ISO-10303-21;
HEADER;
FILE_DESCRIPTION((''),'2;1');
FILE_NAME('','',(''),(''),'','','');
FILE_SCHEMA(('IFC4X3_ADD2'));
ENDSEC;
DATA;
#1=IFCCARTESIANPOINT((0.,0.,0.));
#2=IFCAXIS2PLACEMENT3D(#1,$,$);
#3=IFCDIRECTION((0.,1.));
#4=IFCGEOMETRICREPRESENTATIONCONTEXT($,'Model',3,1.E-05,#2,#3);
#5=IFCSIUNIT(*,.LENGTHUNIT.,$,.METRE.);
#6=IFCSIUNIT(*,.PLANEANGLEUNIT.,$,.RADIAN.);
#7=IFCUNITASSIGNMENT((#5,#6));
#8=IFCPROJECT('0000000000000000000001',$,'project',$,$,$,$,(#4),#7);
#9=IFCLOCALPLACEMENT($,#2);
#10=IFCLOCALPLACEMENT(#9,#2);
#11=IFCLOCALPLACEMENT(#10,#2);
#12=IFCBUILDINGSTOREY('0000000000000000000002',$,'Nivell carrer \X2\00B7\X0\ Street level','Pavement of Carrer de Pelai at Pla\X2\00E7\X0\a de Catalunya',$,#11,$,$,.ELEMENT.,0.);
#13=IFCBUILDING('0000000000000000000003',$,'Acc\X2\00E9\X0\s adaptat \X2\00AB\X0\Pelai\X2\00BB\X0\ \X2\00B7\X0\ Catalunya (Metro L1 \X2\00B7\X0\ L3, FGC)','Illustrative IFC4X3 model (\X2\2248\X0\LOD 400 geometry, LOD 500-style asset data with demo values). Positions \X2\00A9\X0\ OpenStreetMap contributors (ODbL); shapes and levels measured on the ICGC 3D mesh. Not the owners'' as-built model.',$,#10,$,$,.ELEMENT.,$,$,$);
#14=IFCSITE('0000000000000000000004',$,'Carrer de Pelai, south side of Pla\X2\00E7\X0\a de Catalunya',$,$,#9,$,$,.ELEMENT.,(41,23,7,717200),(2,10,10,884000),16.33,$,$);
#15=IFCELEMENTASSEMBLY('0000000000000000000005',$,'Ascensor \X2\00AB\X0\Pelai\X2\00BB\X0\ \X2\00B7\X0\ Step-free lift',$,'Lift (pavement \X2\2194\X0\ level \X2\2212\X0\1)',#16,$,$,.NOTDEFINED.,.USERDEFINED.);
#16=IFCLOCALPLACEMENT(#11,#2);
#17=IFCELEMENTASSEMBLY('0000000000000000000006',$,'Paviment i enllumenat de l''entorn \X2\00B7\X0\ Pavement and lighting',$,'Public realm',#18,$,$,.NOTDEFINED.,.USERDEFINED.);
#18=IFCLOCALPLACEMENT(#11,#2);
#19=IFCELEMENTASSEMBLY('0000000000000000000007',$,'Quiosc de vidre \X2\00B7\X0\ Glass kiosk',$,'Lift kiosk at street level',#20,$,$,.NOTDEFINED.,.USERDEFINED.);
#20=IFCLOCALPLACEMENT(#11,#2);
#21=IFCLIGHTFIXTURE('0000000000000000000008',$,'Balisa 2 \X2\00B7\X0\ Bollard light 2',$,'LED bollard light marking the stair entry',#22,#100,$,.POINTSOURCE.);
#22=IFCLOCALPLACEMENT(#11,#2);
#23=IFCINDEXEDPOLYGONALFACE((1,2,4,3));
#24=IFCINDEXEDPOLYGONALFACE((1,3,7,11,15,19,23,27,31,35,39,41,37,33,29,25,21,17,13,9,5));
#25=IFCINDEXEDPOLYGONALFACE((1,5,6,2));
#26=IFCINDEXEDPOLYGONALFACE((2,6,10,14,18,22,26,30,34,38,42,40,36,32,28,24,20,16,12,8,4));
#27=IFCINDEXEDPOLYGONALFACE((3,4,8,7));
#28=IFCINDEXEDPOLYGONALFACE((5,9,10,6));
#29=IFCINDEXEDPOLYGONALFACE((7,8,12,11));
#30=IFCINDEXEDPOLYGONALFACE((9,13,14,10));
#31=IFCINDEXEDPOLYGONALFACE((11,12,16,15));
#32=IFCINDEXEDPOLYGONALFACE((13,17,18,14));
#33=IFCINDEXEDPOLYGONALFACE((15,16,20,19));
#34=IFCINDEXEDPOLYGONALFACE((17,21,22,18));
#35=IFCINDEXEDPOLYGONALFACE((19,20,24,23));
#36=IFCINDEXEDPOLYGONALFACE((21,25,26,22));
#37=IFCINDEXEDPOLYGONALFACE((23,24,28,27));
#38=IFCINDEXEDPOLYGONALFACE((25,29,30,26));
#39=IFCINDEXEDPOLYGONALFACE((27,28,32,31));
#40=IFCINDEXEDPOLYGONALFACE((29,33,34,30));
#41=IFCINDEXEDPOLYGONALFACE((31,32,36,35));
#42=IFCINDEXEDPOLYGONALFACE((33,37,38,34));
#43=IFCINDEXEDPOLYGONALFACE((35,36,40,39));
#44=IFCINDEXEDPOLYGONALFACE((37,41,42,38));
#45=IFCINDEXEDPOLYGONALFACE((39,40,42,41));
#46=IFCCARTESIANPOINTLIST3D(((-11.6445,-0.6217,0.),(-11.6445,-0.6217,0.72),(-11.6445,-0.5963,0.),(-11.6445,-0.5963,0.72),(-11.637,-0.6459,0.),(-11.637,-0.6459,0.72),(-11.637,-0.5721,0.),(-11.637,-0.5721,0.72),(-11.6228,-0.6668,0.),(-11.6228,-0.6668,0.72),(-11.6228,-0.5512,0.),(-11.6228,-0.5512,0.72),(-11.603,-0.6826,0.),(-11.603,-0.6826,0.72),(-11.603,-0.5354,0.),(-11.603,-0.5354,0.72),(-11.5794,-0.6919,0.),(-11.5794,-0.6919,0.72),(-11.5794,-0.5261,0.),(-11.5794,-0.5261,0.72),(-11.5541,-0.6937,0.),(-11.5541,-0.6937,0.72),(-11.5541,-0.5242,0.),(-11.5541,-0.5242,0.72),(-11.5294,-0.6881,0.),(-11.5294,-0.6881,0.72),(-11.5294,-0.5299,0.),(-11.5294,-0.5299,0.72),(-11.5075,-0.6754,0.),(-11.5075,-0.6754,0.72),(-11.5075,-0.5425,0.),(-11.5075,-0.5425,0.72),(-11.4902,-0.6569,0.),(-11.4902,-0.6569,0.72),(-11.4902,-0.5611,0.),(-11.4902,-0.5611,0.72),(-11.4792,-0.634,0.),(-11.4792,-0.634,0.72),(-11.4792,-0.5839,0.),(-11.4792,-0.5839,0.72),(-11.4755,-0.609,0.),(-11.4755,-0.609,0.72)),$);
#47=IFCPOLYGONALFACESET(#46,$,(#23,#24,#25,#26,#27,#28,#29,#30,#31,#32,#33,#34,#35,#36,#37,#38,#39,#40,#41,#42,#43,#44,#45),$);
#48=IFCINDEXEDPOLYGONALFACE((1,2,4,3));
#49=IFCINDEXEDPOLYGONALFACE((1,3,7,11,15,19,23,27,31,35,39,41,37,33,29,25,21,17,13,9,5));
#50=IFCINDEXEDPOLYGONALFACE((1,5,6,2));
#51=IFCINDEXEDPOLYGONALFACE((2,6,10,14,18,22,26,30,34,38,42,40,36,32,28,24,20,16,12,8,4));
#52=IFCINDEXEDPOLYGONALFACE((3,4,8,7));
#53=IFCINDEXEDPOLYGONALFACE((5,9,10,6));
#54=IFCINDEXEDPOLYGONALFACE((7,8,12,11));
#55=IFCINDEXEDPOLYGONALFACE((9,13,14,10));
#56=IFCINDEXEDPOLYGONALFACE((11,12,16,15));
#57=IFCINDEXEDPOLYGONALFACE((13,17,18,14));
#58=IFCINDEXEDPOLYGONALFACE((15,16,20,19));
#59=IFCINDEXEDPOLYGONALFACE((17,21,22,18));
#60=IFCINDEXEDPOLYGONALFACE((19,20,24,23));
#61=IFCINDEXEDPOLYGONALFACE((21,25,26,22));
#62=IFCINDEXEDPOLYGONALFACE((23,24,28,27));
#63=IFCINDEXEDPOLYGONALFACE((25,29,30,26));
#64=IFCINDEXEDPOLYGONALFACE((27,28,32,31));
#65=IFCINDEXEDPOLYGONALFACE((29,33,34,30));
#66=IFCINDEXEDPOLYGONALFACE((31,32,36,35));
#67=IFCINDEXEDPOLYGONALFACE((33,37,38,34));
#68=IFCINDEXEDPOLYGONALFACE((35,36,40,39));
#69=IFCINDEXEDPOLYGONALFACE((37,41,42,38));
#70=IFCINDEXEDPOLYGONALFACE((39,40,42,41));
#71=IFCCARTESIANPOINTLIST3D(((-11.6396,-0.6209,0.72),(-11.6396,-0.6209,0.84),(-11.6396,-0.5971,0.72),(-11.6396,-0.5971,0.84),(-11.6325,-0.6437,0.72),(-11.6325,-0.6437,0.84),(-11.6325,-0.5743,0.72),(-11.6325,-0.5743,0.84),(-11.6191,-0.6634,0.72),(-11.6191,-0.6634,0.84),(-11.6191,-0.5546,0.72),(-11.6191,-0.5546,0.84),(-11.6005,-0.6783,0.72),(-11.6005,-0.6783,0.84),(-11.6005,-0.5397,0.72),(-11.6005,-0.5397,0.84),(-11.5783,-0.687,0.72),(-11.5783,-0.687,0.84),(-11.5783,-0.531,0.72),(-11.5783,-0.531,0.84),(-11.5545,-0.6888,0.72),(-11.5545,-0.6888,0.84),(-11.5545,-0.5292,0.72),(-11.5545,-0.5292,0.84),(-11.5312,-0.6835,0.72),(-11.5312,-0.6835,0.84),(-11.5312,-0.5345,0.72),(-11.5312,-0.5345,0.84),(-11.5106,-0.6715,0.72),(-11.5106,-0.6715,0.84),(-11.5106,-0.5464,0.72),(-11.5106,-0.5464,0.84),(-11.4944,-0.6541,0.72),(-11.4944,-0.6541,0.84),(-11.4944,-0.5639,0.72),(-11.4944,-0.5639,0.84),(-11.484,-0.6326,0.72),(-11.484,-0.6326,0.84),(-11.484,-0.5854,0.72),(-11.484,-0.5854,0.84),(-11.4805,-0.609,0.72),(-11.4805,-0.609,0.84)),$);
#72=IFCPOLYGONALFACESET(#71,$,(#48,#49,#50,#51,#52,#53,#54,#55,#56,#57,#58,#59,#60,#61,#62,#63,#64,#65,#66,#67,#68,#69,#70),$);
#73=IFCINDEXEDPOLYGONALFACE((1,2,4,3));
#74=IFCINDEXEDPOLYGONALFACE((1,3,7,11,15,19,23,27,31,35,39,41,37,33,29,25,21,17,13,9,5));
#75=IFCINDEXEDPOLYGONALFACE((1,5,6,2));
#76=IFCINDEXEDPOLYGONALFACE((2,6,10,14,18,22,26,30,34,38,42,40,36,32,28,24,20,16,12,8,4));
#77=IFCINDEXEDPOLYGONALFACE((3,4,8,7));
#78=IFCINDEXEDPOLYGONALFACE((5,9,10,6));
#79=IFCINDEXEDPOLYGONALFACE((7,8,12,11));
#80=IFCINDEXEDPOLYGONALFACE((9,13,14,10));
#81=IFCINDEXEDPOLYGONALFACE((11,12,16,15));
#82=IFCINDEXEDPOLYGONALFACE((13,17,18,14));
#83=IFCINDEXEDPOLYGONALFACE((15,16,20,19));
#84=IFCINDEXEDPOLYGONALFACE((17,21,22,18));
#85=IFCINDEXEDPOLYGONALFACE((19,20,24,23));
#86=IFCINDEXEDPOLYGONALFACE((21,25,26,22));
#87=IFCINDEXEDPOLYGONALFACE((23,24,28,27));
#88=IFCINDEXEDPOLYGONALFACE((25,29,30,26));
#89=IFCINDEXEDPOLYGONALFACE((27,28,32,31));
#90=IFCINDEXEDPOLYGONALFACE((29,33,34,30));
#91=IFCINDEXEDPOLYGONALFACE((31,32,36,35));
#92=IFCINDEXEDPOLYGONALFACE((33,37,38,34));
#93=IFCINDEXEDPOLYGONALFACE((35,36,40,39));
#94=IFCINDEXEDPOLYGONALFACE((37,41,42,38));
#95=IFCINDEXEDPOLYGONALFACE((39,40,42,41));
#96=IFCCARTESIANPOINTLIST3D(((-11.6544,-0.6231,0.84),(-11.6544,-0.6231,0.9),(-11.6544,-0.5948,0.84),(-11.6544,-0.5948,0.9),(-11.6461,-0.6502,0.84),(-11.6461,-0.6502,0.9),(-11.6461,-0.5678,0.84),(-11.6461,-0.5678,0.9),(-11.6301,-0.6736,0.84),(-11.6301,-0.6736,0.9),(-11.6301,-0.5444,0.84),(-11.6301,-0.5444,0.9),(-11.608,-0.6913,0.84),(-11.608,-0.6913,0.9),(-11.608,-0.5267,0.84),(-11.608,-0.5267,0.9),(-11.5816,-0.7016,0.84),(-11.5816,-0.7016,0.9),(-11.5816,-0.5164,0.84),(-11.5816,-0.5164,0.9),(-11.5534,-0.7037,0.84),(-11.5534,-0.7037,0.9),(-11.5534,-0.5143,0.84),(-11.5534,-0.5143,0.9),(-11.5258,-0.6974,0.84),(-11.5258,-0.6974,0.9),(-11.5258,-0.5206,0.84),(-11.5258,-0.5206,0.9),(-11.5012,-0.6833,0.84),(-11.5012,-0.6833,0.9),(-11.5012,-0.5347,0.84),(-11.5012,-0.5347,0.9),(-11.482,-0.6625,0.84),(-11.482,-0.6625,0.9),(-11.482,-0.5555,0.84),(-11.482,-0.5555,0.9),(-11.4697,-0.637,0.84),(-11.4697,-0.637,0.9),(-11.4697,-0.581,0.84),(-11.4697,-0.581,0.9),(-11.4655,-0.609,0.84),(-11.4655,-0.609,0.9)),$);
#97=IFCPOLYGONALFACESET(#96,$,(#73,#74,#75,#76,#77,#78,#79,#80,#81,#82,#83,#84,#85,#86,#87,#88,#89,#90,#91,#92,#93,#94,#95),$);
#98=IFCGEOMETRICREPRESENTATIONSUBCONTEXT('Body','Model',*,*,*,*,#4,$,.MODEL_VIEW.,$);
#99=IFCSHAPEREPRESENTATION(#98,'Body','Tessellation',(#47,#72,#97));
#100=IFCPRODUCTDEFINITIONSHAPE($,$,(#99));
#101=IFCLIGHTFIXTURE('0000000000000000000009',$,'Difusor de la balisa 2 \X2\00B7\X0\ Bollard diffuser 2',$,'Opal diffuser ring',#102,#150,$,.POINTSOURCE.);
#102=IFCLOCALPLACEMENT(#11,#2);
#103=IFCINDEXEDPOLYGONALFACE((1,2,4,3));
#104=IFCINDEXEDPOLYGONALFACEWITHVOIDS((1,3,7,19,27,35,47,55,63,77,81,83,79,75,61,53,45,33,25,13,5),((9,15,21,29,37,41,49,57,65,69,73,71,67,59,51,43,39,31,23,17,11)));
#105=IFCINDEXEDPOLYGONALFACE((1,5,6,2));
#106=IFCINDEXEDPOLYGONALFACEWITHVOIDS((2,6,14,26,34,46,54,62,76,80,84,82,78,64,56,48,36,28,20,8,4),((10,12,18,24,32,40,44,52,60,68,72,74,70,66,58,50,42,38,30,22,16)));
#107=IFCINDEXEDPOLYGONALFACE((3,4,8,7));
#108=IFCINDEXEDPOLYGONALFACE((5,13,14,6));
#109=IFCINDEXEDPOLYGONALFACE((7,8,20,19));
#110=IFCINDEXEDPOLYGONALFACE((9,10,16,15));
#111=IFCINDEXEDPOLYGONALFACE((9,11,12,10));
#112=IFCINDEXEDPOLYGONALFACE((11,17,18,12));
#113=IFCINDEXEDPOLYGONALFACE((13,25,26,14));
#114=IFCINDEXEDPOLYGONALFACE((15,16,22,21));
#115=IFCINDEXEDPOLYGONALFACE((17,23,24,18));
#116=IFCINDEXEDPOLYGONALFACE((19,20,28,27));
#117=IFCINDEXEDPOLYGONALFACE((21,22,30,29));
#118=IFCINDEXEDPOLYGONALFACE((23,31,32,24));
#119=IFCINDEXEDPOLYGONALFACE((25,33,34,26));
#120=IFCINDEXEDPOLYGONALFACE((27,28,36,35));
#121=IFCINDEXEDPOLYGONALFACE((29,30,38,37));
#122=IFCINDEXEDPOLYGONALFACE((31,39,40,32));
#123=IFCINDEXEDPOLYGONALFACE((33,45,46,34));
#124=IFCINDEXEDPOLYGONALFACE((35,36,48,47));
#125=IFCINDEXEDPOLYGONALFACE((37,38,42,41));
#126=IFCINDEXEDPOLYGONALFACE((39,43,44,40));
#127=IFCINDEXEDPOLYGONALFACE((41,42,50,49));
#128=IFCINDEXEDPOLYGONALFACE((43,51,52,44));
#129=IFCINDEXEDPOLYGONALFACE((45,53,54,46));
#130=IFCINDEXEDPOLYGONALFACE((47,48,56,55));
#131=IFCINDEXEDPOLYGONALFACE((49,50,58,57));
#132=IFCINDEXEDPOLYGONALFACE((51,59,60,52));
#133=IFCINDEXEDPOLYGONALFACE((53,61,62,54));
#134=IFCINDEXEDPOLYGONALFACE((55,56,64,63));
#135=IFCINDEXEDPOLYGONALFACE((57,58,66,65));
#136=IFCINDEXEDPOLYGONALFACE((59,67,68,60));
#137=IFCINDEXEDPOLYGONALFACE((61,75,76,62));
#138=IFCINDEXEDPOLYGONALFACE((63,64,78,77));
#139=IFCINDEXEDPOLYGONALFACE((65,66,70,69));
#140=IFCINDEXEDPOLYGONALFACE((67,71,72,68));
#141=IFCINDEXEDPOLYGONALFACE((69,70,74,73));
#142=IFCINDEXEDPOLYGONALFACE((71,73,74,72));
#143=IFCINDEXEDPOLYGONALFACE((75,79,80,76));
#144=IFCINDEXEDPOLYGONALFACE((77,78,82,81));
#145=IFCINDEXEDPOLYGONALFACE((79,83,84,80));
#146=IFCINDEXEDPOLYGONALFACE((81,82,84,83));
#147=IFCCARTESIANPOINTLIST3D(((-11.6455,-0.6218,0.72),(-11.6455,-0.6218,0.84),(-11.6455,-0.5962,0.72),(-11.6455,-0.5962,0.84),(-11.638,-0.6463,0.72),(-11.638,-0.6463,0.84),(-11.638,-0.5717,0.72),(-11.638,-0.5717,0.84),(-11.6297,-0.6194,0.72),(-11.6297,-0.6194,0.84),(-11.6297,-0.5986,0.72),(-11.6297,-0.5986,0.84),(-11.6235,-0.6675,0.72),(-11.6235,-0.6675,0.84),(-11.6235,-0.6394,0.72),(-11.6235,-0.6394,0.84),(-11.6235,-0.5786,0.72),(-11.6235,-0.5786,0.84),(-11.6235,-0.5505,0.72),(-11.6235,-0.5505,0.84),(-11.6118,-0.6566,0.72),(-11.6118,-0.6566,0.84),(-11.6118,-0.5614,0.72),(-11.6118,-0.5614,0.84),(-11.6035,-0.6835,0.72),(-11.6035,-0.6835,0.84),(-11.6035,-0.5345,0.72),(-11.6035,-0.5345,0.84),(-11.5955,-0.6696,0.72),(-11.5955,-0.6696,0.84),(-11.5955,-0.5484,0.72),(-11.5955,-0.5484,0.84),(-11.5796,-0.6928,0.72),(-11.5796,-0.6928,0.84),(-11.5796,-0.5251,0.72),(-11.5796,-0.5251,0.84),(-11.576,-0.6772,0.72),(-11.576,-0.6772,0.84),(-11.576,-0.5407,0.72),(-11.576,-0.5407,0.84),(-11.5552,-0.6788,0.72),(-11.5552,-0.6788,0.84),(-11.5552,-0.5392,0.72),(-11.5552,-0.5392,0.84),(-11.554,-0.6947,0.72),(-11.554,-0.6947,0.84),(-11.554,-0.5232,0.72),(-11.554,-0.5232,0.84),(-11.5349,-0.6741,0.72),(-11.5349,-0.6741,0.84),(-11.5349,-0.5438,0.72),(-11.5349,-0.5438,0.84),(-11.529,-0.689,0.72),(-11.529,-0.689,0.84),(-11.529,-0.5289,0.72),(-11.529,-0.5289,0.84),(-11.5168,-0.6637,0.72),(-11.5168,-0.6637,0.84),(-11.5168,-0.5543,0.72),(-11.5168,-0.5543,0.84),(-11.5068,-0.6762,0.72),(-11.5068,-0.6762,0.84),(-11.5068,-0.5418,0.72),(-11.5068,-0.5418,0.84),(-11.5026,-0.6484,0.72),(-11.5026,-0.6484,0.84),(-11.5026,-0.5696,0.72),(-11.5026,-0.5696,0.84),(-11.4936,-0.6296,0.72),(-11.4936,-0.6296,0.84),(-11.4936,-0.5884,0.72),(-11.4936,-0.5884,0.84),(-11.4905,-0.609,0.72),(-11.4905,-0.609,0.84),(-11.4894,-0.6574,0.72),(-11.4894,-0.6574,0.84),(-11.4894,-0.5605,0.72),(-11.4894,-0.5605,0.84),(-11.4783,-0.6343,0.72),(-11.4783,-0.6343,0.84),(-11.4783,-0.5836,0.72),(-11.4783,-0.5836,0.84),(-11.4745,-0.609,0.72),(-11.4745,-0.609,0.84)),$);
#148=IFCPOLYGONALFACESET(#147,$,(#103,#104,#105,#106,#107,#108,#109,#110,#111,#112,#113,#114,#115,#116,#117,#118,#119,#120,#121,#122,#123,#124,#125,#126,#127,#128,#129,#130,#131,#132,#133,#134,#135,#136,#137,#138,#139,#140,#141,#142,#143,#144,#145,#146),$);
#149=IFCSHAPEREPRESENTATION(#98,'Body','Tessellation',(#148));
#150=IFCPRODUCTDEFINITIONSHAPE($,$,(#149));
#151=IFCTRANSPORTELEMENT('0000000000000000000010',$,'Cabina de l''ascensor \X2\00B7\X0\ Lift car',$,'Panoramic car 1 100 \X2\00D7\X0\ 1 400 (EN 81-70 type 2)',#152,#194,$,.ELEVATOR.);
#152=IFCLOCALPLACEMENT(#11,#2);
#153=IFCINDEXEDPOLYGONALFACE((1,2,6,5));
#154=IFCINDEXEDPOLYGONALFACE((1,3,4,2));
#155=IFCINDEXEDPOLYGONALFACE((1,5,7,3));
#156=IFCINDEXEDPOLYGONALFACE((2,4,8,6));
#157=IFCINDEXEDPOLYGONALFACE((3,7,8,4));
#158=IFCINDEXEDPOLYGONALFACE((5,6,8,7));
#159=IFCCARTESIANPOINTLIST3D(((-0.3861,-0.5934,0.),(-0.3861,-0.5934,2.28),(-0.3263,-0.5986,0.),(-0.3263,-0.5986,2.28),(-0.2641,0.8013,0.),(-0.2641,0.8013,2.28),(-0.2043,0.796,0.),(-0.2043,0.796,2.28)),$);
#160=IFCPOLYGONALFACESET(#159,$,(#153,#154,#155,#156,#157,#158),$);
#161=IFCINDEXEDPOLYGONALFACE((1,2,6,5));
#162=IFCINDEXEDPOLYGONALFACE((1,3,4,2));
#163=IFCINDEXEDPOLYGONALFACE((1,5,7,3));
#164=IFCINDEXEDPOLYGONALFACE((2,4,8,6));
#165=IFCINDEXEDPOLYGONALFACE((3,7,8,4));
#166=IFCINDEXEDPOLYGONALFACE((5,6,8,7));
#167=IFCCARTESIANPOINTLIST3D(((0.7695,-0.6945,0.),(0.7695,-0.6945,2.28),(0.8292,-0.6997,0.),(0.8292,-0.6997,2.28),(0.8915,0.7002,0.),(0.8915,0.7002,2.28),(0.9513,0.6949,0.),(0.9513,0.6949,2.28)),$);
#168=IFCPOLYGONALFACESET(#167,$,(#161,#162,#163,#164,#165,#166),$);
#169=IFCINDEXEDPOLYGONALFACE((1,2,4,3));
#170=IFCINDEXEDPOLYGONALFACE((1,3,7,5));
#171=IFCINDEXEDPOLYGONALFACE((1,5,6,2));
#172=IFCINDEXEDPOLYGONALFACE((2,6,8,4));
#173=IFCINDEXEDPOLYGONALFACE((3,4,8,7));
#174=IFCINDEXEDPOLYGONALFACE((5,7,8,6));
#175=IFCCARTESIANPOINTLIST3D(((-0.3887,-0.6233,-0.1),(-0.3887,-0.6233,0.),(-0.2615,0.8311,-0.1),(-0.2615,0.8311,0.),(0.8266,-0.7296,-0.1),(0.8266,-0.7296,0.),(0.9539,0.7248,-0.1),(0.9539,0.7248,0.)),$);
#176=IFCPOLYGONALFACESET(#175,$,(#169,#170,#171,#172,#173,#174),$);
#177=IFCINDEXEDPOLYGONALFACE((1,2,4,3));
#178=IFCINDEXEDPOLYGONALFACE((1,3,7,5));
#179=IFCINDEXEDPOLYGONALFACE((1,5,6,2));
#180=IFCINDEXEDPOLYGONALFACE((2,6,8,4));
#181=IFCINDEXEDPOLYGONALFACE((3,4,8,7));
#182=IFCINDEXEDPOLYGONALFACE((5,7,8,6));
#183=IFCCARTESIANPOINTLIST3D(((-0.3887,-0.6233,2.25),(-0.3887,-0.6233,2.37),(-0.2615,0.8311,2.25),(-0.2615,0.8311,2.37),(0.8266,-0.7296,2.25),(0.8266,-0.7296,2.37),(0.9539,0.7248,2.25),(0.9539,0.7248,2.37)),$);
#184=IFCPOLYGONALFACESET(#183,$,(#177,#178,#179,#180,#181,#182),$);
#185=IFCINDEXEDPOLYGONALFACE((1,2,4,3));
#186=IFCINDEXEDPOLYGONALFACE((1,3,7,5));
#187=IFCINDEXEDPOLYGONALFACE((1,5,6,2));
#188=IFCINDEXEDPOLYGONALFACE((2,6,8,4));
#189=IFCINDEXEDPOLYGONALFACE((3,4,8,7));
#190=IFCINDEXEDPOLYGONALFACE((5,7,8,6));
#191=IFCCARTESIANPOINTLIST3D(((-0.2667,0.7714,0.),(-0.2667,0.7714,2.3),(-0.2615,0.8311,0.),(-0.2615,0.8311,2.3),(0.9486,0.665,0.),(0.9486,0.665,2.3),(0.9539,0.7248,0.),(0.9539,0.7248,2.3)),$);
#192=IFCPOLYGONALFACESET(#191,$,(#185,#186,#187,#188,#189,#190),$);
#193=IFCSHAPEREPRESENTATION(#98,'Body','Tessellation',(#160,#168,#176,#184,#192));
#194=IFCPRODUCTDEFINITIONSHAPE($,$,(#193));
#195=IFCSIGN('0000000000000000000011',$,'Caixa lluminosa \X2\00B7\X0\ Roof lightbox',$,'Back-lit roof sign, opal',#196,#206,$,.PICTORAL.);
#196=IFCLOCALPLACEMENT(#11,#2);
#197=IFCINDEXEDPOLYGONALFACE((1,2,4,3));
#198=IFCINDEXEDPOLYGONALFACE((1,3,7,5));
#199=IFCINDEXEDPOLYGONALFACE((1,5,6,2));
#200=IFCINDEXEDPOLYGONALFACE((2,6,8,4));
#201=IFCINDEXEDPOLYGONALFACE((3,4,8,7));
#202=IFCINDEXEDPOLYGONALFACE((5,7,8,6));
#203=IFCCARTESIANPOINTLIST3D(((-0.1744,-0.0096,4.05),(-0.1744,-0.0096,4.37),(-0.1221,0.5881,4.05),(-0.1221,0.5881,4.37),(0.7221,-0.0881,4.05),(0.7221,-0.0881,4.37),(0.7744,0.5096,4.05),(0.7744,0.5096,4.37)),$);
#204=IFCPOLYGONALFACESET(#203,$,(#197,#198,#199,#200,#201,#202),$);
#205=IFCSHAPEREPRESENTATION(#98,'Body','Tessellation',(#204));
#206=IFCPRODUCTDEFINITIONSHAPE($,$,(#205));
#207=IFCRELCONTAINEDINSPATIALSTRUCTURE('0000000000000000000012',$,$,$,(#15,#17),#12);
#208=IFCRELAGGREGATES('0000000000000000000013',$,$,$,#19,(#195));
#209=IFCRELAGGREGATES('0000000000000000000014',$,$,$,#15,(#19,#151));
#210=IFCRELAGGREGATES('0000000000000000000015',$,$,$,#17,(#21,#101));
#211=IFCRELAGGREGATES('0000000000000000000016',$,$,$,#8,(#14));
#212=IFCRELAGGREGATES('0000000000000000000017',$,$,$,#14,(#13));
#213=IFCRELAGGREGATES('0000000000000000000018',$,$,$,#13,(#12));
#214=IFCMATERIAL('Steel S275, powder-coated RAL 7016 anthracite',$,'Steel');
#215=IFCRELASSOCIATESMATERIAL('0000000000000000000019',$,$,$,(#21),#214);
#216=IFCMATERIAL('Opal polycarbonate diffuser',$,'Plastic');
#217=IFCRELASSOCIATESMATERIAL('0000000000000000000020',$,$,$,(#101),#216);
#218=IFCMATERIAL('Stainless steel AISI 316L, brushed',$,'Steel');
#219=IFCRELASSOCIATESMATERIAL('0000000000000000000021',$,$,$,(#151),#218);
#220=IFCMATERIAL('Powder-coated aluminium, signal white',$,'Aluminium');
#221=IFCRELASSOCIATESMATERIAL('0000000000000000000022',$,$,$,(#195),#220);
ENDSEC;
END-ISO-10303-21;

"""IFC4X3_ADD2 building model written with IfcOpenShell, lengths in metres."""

from ifc_helpers import new_model, si_unit, direction, frame, frame_2d, origin, origin_2d_with_axis, place, context, subcontext, project, spatial, rectangle, circle, hollow_circle, extrude, material, element, aggregate, save


model = new_model("IFC4X3_ADD2")

# Units and contexts
model_context = context("Model", 3, precision=1e-05, world=origin(), true_north=direction((0.0, 1.0)))
body_context = subcontext(model_context, "Body", "Model", "MODEL_VIEW")
ifc_project = project(units=[si_unit("LENGTHUNIT", "METRE"), si_unit("PLANEANGLEUNIT", "RADIAN")], contexts=[model_context])

# Site, building, storey
site_placement = place(None, origin())
site = spatial("IfcSite", under=ifc_project, at=site_placement, Name="Carrer de Pelai, south side of Plaça de Catalunya", CompositionType="ELEMENT", RefLatitude=(41, 23, 7, 717200), RefLongitude=(2, 10, 10, 884000), RefElevation=16.33)
building_placement = place(site_placement, origin())
building = spatial("IfcBuilding", under=site, at=building_placement, Name="Accés adaptat «Pelai» · Catalunya (Metro L1 · L3, FGC)", Description="Illustrative IFC4X3 model (≈LOD 400 geometry, LOD 500-style asset data with demo values). Positions © OpenStreetMap contributors (ODbL); shapes and levels measured on the ICGC 3D mesh. Not the owners' as-built model.", CompositionType="ELEMENT")
storey_placement = place(building_placement, origin())
storey = spatial("IfcBuildingStorey", under=building, at=storey_placement, Name="Nivell carrer · Street level", Description="Pavement of Carrer de Pelai at Plaça de Catalunya", CompositionType="ELEMENT", Elevation=0.0)

# Element assembly
assembly_1_placement = place(building_placement, origin())
assembly_1 = element("IfcElementAssembly", 1, at=assembly_1_placement, inside=storey, Name="Ascensor «Pelai» · Step-free lift", ObjectType="Lift (pavement ↔ level −1)", AssemblyPlace="NOTDEFINED", PredefinedType="USERDEFINED")
ifc_material_1 = material(Name="Stainless steel AISI 316L, brushed", Category="Steel")
ifc_material_2 = material(Name="Steel S275, powder-coated RAL 7016 anthracite", Category="Steel")

# Element assembly
assembly_2_placement = place(building_placement, origin())
assembly_2 = element("IfcElementAssembly", 2, at=assembly_2_placement, inside=storey, Name="Paviment i enllumenat de l'entorn · Pavement and lighting", ObjectType="Public realm", AssemblyPlace="NOTDEFINED", PredefinedType="USERDEFINED")

# Element assembly
assembly_3_placement = place(building_placement, origin())
assembly_3 = element("IfcElementAssembly", 3, at=assembly_3_placement, Name="Quiosc de vidre · Glass kiosk", ObjectType="Lift kiosk at street level", AssemblyPlace="NOTDEFINED", PredefinedType="USERDEFINED")
ifc_material_3 = material(Name="Opal polycarbonate diffuser", Category="Plastic")

# Light fixtures
light_fixture_1_placement = place(building_placement, origin())
light_fixture_1 = element("IfcLightFixture", 4, at=light_fixture_1_placement, material=ifc_material_2, Name="Balisa 2 · Bollard light 2", ObjectType="LED bollard light marking the stair entry", PredefinedType="POINTSOURCE", context=body_context, shape_type="SweptSolid", body=[
    extrude(circle(Radius=0.085, at=origin_2d_with_axis()), frame((-11.5605, -0.609, 0.0)), (0.0, 0.0, 1.0), 0.72),
    extrude(circle(Radius=0.08, at=origin_2d_with_axis()), frame((-11.5605, -0.609, 0.72)), (0.0, 0.0, 1.0), 0.12),
    extrude(circle(Radius=0.095, at=origin_2d_with_axis()), frame((-11.5605, -0.609, 0.84)), (0.0, 0.0, 1.0), 0.06),
])
light_fixture_2_placement = place(building_placement, origin())
light_fixture_2 = element("IfcLightFixture", 5, at=light_fixture_2_placement, material=ifc_material_3, Name="Difusor de la balisa 2 · Bollard diffuser 2", ObjectType="Opal diffuser ring", PredefinedType="POINTSOURCE", context=body_context, shape_type="SweptSolid", body=[
    extrude(hollow_circle(Radius=0.086, WallThickness=0.016, at=origin_2d_with_axis()), frame((-11.5605, -0.609, 0.72)), (0.0, 0.0, 1.0), 0.12),
])

# Transport element
transport_element_placement = place(building_placement, origin())
transport_element = element("IfcTransportElement", 6, at=transport_element_placement, material=ifc_material_1, Name="Cabina de l'ascensor · Lift car", ObjectType="Panoramic car 1 100 × 1 400 (EN 81-70 type 2)", PredefinedType="ELEVATOR", context=body_context, shape_type="SweptSolid", body=[
    extrude(rectangle(XDim=0.06, YDim=1.4, at=frame_2d((0.0, 0.0), x_axis=(0.996195, -0.087156))), frame((-0.2952, 0.1013, 0.0)), (0.0, 0.0, 1.0), 2.28),
    extrude(rectangle(XDim=0.06, YDim=1.4, at=frame_2d((0.0, 0.0), x_axis=(0.996195, -0.087156))), frame((0.8604, 0.0002, 0.0)), (0.0, 0.0, 1.0), 2.28),
    extrude(rectangle(XDim=1.22, YDim=1.46, at=frame_2d((0.0, 0.0), x_axis=(0.996195, -0.087156))), frame((0.2826, 0.0508, -0.1)), (0.0, 0.0, 1.0), 0.1),
    extrude(rectangle(XDim=1.22, YDim=1.46, at=frame_2d((0.0, 0.0), x_axis=(0.996195, -0.087156))), frame((0.2826, 0.0508, 2.25)), (0.0, 0.0, 1.0), 0.12),
    extrude(rectangle(XDim=1.22, YDim=0.06, at=frame_2d((0.0, 0.0), x_axis=(0.996195, -0.087156))), frame((0.3436, 0.7481, 0.0)), (0.0, 0.0, 1.0), 2.3),
])

# Sign
ifc_material_4 = material(Name="Powder-coated aluminium, signal white", Category="Aluminium")
sign_1_placement = place(building_placement, origin())
sign_1 = element("IfcSign", 7, at=sign_1_placement, material=ifc_material_4, Name="Caixa lluminosa · Roof lightbox", ObjectType="Back-lit roof sign, opal", PredefinedType="PICTORAL", context=body_context, shape_type="SweptSolid", body=[
    extrude(rectangle(XDim=0.9, YDim=0.6, at=frame_2d((0.0, 0.0), x_axis=(0.996195, -0.087156))), frame((0.3, 0.25, 4.05)), (0.0, 0.0, 1.0), 0.32),
])
aggregate(assembly_3, [sign_1])

aggregate(assembly_1, [assembly_3, transport_element])

aggregate(assembly_2, [light_fixture_1, light_fixture_2])

save(model, "model.ifc")
